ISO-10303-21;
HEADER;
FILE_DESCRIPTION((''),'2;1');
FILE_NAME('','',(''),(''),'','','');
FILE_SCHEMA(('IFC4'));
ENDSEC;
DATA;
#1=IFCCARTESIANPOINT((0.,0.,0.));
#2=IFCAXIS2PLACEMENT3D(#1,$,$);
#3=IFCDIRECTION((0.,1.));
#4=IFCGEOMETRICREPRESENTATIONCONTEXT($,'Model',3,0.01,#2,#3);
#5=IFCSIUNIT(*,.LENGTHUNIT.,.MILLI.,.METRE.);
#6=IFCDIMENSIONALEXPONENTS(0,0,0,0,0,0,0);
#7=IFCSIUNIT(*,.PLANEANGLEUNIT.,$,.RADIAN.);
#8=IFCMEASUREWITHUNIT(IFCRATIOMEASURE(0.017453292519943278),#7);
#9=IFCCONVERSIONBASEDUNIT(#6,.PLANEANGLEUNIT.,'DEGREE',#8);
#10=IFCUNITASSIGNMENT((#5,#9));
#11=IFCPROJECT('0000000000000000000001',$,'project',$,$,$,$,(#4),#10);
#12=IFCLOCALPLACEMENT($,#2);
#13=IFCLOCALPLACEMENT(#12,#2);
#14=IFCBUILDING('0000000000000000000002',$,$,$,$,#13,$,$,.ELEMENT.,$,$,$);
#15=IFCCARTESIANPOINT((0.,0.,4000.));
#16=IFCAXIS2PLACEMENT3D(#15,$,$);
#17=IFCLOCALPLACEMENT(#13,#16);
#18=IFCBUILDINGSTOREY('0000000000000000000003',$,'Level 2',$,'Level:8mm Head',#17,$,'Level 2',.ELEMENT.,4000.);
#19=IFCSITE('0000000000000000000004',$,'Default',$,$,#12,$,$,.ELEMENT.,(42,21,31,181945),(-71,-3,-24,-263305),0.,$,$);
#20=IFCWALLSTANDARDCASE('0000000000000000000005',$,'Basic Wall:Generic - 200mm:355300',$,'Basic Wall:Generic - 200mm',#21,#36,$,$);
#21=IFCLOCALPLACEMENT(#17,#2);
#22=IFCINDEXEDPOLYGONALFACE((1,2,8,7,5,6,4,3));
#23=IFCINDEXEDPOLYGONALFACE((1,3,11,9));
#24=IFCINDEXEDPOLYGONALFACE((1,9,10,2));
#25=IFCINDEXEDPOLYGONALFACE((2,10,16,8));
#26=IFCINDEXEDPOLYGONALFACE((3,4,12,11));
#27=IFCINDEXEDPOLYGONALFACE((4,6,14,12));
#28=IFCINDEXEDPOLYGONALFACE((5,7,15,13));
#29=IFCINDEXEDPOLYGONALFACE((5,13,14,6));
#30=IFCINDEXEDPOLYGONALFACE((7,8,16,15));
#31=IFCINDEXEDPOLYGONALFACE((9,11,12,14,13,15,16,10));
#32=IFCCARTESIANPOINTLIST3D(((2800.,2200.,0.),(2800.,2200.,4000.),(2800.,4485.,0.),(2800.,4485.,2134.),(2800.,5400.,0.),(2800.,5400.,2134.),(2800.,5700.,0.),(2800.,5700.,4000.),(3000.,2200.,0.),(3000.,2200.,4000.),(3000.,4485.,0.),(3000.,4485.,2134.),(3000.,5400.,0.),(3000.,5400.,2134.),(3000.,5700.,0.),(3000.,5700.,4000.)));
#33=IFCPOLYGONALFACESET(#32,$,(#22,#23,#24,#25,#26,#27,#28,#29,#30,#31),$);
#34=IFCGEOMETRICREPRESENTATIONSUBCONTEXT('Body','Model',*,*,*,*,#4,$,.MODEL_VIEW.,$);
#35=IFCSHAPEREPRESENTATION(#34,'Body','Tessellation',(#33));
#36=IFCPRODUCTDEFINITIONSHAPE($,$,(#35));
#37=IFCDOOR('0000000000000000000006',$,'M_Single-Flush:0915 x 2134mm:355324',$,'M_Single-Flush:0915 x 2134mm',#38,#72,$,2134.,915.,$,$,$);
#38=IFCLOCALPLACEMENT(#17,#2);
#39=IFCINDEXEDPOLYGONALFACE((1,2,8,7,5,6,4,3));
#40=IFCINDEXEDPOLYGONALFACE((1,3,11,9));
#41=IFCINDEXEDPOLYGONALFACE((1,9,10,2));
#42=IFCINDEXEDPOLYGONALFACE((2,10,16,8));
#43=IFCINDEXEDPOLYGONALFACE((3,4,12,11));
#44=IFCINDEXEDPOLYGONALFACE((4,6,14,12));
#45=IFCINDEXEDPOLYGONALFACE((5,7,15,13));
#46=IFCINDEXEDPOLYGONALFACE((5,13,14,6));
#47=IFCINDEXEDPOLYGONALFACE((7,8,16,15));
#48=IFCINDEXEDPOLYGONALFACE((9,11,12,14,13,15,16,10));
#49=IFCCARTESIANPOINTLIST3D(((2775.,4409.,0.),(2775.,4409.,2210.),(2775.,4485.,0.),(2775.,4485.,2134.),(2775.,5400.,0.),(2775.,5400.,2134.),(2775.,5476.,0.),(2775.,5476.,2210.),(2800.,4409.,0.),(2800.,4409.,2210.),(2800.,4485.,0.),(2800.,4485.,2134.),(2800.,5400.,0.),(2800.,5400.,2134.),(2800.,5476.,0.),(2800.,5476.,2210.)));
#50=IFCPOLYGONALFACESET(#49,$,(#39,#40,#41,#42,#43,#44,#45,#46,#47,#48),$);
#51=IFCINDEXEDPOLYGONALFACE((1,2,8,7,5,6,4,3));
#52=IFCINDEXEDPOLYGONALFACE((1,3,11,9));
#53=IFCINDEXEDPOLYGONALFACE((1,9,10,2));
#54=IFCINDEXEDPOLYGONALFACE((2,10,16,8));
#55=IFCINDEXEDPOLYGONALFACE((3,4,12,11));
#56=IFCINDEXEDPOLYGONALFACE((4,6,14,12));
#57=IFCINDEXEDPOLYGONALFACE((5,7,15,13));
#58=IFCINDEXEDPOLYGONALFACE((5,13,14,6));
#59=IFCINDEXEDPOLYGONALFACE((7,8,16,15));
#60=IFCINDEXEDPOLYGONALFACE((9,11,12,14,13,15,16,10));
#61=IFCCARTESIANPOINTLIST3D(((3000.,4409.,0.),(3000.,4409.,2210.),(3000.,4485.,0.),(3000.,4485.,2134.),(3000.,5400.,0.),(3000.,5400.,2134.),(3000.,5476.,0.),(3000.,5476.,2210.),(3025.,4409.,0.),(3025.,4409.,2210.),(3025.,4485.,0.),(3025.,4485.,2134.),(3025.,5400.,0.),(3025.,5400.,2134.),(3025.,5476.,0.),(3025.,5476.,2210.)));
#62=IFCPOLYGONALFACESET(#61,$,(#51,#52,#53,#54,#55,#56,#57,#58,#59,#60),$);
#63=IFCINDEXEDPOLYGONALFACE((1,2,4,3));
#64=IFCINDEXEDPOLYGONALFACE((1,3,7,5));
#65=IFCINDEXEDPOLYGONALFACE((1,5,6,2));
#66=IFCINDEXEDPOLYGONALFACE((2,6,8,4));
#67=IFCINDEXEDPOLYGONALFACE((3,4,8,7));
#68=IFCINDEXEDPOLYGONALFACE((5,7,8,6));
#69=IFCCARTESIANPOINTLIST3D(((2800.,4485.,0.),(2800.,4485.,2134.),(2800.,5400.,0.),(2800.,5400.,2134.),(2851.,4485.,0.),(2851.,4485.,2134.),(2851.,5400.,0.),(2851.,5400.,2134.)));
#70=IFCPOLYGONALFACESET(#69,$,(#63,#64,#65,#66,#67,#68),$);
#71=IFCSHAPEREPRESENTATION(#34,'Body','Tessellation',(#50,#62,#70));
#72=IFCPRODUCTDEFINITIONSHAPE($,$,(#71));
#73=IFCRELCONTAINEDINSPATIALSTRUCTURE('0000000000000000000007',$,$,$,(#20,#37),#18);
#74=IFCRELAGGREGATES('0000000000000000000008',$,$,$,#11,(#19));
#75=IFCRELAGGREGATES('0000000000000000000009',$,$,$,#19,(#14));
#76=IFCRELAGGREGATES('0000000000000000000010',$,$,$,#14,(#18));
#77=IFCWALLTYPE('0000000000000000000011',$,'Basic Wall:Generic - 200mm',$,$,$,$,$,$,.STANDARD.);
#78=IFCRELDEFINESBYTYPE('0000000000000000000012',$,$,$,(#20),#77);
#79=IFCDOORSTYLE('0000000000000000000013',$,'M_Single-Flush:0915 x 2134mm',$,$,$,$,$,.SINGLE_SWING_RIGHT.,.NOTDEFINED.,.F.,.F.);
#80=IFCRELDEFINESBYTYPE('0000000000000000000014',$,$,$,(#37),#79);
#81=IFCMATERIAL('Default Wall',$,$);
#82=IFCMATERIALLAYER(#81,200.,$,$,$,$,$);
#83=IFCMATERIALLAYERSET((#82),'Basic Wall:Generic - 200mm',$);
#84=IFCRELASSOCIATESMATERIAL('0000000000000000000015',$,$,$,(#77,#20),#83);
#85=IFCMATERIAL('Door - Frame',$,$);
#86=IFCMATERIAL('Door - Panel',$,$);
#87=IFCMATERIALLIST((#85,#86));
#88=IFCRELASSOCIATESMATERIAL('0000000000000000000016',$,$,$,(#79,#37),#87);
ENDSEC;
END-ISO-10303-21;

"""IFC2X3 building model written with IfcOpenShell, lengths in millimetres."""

from ifc_helpers import new_model, entity, si_unit, converted_unit, direction, frame, frame_2d, origin, place, context, subcontext, project, spatial, polyline, rectangle, outline, extrude, source, transform, mapped, material, material_list, layer, layer_set, layer_usage, type_object, type_shapes, element, fill, save


model = new_model("IFC2X3")

# Units and contexts
model_context = context("Model", 3, precision=0.01, world=origin(), true_north=direction((0.0, 1.0)))
body_context = subcontext(model_context, "Body", "Model", "MODEL_VIEW")
ifc_project = project(units=[si_unit("LENGTHUNIT", "METRE", prefix="MILLI"), converted_unit("PLANEANGLEUNIT", "DEGREE", entity("IfcRatioMeasure", 0.017453292519943278), si_unit("PLANEANGLEUNIT", "RADIAN"), dimensions=[0, 0, 0, 0, 0, 0, 0])], contexts=[model_context])

# Site, building, storey
site_placement = place(None, origin())
site = spatial("IfcSite", under=ifc_project, at=site_placement, Name="Default", CompositionType="ELEMENT", RefLatitude=(42, 21, 31, 181945), RefLongitude=(-71, -3, -24, -263305), RefElevation=0.0)
building_placement = place(site_placement, origin())
building = spatial("IfcBuilding", under=site, at=building_placement, CompositionType="ELEMENT")
storey_placement = place(building_placement, frame((0.0, 0.0, 4000.0)))
storey = spatial("IfcBuildingStorey", under=building, at=storey_placement, Name="Level 2", ObjectType="Level:8mm Head", LongName="Level 2", CompositionType="ELEMENT", Elevation=4000.0)

# Shared definitions
ifc_material_1 = material(Name="Default Wall")
ifc_layer_1 = layer(ifc_material_1, 200.0)
ifc_layer_set_1 = layer_set([ifc_layer_1], Name="Basic Wall:Generic - 200mm")
ifc_layer_usage_1 = layer_usage(ifc_layer_set_1, "AXIS2", "NEGATIVE", 100.0)
wall_type = type_object("IfcWallType", Name="Basic Wall:Generic - 200mm", PredefinedType="STANDARD", material=ifc_layer_set_1)

# Shared definitions
ifc_material_2 = material(Name="Door - Frame")
ifc_material_3 = material(Name="Door - Panel")
ifc_material_list = material_list([ifc_material_2, ifc_material_3])
door_style = type_object("IfcDoorStyle", Name="M_Single-Flush:0915 x 2134mm", ConstructionType="NOTDEFINED", OperationType="SINGLE_SWING_RIGHT", ParameterTakesPrecedence=False, Sizeable=False, material=ifc_material_list)
shared_shape = source(origin(), body_context, "Body", "SweptSolid", [
    extrude(outline(polyline([(-533.5, -1124.0), (533.5, -1124.0), (533.5, 1086.0), (457.5, 1086.0), (457.5, -1048.0), (-457.5, -1048.0), (-457.5, 1086.0), (-533.5, 1086.0), (-533.5, -1124.0)])), frame((457.5, 200.0, 1086.0), z_axis=(0.0, 1.0, 0.0), x_axis=(1.0, 0.0, 0.0)), (0.0, 0.0, 1.0), 25.0),
    extrude(outline(polyline([(-1124.0, -533.5), (1086.0, -533.5), (1086.0, -457.5), (-1048.0, -457.5), (-1048.0, 457.5), (1086.0, 457.5), (1086.0, 533.5), (-1124.0, 533.5), (-1124.0, -533.5)])), frame((457.5, -25.0, 1086.0), z_axis=(0.0, 1.0, 0.0), x_axis=(0.0, 0.0, -1.0)), (0.0, 0.0, 1.0), 25.0),
    extrude(rectangle(XDim=51.0, YDim=915.0, at=frame_2d((0.0, 0.0), x_axis=(1.0, 0.0))), frame((457.5, 174.5, 0.0), z_axis=(0.0, 0.0, 1.0), x_axis=(0.0, 1.0, 0.0)), (0.0, 0.0, 1.0), 2134.0),
])
type_shapes(door_style, [shared_shape])

# Wall, opening, door
wall_1_placement = place(storey_placement, frame((2900.0, 5700.0, 0.0), z_axis=(0.0, 0.0, 1.0), x_axis=(0.0, -1.0, 0.0)))
wall_1 = element("IfcWallStandardCase", 1, at=wall_1_placement, inside=storey, type_object=wall_type, material=ifc_layer_usage_1, Name="Basic Wall:Generic - 200mm:355300", ObjectType="Basic Wall:Generic - 200mm", context=body_context, shape_type="SweptSolid", body=[
    extrude(rectangle(XDim=3500.0, YDim=200.0, at=frame_2d((1750.0, 0.0), x_axis=(-1.0, 0.0))), origin(), (0.0, 0.0, 1.0), 4000.0),
])
opening_1_placement = place(wall_1_placement, frame((1215.0, 100.0, 0.0)))
opening_1 = element("IfcOpeningElement", 2, at=opening_1_placement, cuts=wall_1, ObjectType="Opening", context=body_context, shape_type="SweptSolid", body=[
    extrude(rectangle(XDim=915.0, YDim=2134.0, at=frame_2d((1067.0, 457.5), x_axis=(0.0, 1.0))), frame((0.0, 0.0, 0.0), z_axis=(0.0, -1.0, 0.0), x_axis=(0.0, 0.0, 1.0)), (0.0, 0.0, 1.0), 200.0),
])
door_1_placement = place(opening_1_placement, frame((0.0, 0.0, 0.0), z_axis=(0.0, 0.0, 1.0), x_axis=(-1.0, 0.0, 0.0)))
door_1 = element("IfcDoor", 3, at=door_1_placement, inside=storey, type_object=door_style, material=ifc_material_list, Name="M_Single-Flush:0915 x 2134mm:355324", ObjectType="M_Single-Flush:0915 x 2134mm", OverallHeight=2134.0, OverallWidth=915.0, context=body_context, shape_type="MappedRepresentation", body=[
    mapped(shared_shape, transform((0.0, 0.0, 0.0), scale=1.0)),
])
fill(opening_1, door_1)

save(model, "model.ifc")
